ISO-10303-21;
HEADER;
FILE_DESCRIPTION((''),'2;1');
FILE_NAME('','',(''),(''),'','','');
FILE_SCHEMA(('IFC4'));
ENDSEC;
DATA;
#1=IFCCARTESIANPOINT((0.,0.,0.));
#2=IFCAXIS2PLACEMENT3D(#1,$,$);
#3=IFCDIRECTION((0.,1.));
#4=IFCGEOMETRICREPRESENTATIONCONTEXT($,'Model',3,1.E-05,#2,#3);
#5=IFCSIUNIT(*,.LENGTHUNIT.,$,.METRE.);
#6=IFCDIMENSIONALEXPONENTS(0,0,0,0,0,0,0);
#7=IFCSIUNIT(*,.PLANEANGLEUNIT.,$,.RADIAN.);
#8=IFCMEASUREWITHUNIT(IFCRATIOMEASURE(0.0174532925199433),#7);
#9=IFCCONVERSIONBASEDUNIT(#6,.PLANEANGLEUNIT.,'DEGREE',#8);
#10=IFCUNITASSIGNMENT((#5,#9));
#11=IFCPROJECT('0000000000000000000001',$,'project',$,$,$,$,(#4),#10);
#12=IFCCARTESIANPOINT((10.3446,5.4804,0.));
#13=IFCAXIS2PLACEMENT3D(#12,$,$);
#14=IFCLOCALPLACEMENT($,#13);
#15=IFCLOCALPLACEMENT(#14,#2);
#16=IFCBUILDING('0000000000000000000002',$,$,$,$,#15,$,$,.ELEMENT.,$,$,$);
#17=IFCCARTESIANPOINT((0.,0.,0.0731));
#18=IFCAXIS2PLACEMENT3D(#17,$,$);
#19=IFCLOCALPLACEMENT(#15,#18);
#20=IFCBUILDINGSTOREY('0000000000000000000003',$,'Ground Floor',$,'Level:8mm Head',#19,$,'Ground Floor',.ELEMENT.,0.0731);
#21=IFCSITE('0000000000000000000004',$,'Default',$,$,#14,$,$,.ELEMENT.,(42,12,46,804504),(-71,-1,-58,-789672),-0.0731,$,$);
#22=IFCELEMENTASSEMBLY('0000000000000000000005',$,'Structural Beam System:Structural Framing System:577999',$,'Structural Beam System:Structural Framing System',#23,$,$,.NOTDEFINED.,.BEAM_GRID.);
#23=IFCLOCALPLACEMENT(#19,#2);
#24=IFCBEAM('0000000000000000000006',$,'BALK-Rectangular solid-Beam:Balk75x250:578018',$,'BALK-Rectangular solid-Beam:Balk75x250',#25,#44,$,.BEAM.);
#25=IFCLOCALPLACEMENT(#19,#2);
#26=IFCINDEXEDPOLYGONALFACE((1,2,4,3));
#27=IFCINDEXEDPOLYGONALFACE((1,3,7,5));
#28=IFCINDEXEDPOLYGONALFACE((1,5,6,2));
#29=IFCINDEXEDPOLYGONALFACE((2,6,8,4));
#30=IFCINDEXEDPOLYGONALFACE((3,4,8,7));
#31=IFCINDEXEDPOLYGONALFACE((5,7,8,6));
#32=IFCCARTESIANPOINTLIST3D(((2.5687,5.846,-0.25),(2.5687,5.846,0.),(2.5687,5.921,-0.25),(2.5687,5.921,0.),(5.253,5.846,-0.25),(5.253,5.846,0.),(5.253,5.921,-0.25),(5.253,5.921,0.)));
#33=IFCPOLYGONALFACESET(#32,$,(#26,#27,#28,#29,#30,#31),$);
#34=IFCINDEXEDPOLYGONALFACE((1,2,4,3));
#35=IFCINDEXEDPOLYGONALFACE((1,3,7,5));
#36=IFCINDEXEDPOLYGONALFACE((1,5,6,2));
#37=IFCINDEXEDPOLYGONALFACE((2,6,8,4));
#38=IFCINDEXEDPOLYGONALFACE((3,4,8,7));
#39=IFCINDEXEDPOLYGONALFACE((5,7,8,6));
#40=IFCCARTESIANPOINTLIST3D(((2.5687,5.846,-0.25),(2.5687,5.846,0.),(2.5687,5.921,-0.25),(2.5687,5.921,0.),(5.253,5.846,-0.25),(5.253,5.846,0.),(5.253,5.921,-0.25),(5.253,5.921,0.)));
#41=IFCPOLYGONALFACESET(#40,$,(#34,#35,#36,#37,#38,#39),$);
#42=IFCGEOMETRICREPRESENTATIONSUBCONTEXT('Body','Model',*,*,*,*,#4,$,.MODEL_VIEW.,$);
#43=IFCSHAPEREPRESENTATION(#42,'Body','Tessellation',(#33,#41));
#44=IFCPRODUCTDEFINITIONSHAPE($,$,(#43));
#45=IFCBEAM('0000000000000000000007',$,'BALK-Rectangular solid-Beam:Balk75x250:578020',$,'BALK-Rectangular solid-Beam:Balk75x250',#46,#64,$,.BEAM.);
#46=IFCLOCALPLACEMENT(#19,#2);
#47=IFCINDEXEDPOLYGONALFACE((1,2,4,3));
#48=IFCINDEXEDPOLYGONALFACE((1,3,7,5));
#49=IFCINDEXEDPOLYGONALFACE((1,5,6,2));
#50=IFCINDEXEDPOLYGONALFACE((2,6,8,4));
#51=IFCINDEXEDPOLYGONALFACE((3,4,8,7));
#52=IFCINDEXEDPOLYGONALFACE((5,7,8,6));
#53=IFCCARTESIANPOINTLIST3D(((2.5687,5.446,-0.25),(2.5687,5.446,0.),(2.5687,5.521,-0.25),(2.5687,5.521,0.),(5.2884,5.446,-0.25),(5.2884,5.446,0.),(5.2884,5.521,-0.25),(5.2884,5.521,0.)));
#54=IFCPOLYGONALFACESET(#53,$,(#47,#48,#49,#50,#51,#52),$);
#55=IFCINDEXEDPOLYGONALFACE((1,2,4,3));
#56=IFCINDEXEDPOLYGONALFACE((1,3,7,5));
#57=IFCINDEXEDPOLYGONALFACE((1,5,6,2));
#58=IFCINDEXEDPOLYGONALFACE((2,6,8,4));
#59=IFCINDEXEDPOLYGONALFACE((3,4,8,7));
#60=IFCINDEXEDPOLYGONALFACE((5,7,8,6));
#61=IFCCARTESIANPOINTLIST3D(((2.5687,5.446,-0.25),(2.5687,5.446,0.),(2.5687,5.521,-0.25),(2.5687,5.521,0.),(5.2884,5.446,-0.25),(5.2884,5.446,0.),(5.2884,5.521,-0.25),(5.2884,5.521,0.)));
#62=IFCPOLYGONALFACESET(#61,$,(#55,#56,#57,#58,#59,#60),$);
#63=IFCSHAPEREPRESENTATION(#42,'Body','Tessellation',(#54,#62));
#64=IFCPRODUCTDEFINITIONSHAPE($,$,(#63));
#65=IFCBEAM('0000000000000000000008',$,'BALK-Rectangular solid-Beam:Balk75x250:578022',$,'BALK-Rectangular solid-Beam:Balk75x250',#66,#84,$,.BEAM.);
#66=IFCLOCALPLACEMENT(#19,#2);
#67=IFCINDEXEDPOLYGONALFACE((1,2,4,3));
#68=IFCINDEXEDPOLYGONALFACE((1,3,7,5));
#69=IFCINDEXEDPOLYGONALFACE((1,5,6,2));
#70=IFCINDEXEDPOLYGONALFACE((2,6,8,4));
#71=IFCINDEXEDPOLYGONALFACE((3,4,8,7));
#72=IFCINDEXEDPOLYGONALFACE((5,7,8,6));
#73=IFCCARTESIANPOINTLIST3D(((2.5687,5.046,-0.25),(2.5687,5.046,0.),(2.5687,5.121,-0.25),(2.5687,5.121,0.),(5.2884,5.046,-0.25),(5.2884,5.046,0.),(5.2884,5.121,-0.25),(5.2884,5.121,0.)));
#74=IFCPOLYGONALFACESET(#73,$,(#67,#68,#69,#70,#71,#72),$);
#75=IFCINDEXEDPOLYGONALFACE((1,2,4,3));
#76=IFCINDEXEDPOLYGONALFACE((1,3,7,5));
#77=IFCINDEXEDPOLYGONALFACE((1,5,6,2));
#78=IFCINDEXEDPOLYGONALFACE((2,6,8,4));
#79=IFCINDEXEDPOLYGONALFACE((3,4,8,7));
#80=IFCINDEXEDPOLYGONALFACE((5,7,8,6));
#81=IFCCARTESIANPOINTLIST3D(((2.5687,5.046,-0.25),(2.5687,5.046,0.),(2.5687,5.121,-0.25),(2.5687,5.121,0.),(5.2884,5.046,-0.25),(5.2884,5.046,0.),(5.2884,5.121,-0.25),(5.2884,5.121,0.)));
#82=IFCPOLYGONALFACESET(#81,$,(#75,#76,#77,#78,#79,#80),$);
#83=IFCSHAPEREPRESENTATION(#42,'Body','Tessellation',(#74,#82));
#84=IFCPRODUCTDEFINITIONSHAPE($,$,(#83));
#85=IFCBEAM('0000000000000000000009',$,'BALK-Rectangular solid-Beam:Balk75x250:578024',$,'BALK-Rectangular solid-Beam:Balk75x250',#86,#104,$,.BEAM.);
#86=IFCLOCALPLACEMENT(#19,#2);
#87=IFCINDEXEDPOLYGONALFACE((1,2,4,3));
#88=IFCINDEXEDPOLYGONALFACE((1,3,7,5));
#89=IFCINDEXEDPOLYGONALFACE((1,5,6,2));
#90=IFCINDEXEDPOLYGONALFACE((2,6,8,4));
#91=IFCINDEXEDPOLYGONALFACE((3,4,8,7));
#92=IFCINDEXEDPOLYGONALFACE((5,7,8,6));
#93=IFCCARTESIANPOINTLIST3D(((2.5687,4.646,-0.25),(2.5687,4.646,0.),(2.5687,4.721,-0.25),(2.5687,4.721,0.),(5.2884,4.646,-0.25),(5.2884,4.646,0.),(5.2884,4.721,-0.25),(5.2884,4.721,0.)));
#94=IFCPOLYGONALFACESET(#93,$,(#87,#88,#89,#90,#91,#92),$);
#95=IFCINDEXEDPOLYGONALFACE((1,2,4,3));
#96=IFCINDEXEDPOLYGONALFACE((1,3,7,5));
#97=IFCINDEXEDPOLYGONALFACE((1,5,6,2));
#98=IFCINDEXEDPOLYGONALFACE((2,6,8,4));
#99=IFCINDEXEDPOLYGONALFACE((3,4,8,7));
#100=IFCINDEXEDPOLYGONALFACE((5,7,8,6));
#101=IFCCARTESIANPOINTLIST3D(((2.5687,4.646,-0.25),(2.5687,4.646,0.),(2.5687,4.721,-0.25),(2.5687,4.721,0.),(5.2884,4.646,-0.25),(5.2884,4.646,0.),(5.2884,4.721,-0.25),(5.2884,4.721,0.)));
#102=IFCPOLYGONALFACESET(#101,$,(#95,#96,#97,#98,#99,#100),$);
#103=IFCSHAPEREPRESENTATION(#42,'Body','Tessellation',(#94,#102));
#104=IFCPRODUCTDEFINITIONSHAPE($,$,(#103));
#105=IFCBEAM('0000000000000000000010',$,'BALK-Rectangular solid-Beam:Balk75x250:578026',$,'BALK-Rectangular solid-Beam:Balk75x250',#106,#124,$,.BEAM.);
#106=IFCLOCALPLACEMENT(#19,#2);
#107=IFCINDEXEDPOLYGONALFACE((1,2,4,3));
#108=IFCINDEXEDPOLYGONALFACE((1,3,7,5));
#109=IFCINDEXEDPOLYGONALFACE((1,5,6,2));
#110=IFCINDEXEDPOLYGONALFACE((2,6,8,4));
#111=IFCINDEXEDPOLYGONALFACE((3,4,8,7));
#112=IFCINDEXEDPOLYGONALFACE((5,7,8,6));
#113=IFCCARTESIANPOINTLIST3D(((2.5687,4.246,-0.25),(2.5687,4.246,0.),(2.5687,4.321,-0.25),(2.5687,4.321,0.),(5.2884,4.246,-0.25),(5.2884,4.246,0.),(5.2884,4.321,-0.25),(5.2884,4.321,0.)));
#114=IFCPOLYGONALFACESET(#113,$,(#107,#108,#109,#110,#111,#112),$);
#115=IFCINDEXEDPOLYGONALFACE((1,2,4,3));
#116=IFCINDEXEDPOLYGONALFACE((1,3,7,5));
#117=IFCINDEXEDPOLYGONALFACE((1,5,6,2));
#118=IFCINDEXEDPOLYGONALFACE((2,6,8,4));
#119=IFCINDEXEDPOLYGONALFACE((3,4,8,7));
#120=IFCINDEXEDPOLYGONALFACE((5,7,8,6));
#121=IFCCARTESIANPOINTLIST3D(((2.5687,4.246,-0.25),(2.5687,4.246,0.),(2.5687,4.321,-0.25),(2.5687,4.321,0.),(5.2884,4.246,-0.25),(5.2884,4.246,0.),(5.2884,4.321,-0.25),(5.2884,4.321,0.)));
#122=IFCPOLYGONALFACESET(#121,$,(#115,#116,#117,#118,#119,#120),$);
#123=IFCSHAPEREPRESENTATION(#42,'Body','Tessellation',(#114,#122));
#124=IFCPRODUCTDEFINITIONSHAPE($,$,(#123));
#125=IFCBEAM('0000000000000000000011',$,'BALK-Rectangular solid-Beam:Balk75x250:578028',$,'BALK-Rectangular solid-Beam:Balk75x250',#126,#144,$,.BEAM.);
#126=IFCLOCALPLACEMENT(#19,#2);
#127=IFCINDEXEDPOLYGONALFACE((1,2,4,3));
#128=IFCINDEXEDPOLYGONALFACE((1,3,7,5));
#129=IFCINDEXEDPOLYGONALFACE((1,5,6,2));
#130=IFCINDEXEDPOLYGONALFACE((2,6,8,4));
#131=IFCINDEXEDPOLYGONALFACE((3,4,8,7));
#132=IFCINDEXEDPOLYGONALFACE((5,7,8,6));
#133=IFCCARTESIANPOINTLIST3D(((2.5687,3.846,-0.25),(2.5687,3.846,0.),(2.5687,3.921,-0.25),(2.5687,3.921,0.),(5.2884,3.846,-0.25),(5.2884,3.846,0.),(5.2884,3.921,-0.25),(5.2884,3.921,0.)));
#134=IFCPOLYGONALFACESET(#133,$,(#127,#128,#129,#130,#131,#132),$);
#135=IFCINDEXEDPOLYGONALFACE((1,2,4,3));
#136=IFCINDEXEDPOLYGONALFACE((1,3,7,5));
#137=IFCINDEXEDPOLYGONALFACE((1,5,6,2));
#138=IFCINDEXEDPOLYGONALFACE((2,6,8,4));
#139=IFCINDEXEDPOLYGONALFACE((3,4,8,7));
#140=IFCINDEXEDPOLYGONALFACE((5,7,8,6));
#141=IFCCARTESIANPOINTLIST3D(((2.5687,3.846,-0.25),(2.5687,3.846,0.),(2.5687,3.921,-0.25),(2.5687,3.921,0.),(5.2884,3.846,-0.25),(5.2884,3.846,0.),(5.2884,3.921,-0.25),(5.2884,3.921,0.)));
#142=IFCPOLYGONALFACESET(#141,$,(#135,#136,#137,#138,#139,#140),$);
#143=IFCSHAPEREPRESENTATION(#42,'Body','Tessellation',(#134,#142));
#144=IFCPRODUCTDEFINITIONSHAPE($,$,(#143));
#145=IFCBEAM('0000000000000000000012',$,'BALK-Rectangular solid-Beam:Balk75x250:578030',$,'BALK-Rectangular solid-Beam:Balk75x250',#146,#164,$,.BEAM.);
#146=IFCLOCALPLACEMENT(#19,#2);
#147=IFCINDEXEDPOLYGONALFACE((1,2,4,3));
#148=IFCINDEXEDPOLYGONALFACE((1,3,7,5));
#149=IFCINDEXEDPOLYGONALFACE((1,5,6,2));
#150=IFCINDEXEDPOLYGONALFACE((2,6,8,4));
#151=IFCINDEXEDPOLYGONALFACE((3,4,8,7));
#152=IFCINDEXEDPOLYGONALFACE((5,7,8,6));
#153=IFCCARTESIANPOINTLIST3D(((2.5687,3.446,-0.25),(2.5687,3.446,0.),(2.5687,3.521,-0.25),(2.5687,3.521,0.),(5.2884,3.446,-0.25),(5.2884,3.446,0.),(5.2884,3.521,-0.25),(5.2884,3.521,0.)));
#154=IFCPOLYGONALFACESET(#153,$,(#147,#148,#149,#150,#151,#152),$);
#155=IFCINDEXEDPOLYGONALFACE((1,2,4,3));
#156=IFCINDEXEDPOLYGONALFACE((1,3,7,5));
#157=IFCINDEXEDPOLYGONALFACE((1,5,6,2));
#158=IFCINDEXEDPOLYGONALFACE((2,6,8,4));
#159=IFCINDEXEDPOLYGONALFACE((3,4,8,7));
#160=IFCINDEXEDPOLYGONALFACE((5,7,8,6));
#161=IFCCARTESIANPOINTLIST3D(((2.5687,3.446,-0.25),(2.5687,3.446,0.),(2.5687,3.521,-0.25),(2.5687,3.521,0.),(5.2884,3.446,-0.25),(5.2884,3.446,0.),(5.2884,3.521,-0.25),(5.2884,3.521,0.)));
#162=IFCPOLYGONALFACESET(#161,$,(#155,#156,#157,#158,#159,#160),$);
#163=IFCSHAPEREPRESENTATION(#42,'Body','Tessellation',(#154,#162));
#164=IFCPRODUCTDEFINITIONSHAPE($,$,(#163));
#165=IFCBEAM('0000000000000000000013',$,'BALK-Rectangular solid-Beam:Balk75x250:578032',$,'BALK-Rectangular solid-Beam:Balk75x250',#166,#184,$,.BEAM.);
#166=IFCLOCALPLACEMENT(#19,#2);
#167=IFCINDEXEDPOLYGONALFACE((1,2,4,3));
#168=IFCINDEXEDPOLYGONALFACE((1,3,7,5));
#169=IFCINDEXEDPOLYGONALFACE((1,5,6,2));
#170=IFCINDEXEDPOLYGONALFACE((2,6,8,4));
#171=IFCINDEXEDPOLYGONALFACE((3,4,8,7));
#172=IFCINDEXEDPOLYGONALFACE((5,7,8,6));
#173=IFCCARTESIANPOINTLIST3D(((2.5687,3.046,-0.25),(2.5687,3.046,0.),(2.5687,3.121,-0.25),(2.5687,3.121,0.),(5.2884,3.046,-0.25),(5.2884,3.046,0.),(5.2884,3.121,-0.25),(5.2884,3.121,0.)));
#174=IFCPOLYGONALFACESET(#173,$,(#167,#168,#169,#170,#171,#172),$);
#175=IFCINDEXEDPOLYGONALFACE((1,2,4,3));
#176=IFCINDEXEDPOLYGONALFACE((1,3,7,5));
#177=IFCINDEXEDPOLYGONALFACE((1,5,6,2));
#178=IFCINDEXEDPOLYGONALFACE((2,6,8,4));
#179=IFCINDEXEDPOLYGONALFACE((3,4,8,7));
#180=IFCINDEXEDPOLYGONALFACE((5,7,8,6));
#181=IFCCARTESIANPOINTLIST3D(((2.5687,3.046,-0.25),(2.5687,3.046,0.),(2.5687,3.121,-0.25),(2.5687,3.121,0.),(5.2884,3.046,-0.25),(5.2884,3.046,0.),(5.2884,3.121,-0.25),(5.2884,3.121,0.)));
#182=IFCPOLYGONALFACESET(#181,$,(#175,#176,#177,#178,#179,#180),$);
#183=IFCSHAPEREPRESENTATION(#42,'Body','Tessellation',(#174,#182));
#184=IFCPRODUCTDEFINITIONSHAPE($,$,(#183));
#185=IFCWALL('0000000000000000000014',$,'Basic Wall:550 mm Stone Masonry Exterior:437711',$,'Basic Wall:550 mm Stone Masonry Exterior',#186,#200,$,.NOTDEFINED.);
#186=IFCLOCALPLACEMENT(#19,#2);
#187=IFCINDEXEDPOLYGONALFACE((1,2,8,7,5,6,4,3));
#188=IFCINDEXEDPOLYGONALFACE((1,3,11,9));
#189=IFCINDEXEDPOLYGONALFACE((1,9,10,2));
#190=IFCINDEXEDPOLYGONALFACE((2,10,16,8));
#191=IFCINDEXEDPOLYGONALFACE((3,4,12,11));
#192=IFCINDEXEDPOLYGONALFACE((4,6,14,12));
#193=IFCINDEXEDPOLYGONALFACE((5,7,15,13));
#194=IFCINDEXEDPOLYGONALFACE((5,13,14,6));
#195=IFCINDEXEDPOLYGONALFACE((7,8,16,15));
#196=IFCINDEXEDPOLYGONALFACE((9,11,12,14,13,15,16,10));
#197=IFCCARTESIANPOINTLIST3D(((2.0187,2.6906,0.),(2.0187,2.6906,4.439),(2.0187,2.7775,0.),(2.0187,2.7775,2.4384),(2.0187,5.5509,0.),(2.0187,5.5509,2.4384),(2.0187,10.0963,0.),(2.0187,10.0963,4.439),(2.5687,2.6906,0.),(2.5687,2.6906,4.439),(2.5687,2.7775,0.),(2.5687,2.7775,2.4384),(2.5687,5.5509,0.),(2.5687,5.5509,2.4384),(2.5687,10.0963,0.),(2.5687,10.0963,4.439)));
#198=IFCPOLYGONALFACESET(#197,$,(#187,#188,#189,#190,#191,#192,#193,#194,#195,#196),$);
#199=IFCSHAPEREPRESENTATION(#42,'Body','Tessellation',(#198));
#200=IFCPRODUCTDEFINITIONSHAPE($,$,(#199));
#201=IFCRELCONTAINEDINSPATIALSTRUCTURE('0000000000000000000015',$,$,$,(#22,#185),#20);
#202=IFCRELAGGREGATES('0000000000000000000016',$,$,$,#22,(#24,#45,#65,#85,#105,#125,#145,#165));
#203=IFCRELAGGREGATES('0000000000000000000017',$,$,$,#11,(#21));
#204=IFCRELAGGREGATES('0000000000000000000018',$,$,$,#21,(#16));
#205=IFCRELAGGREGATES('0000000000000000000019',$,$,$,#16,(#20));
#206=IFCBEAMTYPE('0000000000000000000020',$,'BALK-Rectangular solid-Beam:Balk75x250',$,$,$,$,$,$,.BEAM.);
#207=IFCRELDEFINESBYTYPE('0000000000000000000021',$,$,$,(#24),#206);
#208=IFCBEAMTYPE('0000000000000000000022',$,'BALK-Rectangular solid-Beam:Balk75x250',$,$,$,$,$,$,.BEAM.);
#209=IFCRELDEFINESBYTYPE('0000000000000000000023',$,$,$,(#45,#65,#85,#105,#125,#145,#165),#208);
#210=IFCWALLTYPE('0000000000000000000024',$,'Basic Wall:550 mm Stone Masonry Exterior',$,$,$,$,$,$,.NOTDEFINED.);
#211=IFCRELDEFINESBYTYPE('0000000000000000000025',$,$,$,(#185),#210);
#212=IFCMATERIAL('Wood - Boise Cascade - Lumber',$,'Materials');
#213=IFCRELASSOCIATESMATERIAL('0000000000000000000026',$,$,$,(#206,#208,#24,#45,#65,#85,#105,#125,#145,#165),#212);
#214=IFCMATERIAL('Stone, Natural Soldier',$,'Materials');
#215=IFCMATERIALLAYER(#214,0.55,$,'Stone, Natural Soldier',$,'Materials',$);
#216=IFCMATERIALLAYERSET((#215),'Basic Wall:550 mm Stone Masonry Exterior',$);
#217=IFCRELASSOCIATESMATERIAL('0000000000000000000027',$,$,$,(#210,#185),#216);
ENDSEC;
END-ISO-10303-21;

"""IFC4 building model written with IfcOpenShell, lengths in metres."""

from ifc_helpers import new_model, entity, si_unit, converted_unit, direction, frame, frame_2d, origin, origin_2d_with_axis, place, context, subcontext, project, spatial, rectangle, extrude, source, transform, mapped, material, layer, layer_set, layer_usage, material_profile, profile_set, profile_usage, type_object, type_shapes, element, aggregate, save


model = new_model("IFC4")

# Units and contexts
model_context = context("Model", 3, precision=1e-05, world=origin(), true_north=direction((0.0, 1.0)))
body_context = subcontext(model_context, "Body", "Model", "MODEL_VIEW")
ifc_project = project(units=[si_unit("LENGTHUNIT", "METRE"), converted_unit("PLANEANGLEUNIT", "DEGREE", entity("IfcRatioMeasure", 0.0174532925199433), si_unit("PLANEANGLEUNIT", "RADIAN"), dimensions=[0, 0, 0, 0, 0, 0, 0])], contexts=[model_context])

# Site, building, storey
site_placement = place(None, frame((10.3446, 5.4804, 0.0)))
site = spatial("IfcSite", under=ifc_project, at=site_placement, Name="Default", CompositionType="ELEMENT", RefLatitude=(42, 12, 46, 804504), RefLongitude=(-71, -1, -58, -789672), RefElevation=-0.0731)
building_placement = place(site_placement, origin())
building = spatial("IfcBuilding", under=site, at=building_placement, CompositionType="ELEMENT")
storey_placement = place(building_placement, frame((0.0, 0.0, 0.0731)))
storey = spatial("IfcBuildingStorey", under=building, at=storey_placement, Name="Ground Floor", ObjectType="Level:8mm Head", LongName="Ground Floor", CompositionType="ELEMENT", Elevation=0.0731)

# Shared definitions
ifc_material_1 = material(Name="Wood - Boise Cascade - Lumber", Category="Materials")
ifc_material_profile = material_profile(ifc_material_1, rectangle(XDim=0.25, YDim=0.075, at=frame_2d((0.0, 0.0), x_axis=(1.0, 0.0))), Name="Balk75x250")
ifc_profile_set = profile_set([ifc_material_profile], Name="Balk75x250")

# Element assembly, beams
assembly_1_placement = place(storey_placement, origin())
assembly_1 = element("IfcElementAssembly", 1, at=assembly_1_placement, inside=storey, Name="Structural Beam System:Structural Framing System:577999", ObjectType="Structural Beam System:Structural Framing System", AssemblyPlace="NOTDEFINED", PredefinedType="BEAM_GRID")
beam_type_1 = type_object("IfcBeamType", Name="BALK-Rectangular solid-Beam:Balk75x250", PredefinedType="BEAM", material=ifc_profile_set)
shared_shape_1 = source(origin(), body_context, "Body", "SweptSolid", [
    extrude(rectangle(XDim=0.25, YDim=0.075, at=origin_2d_with_axis()), frame((-1.3484, 0.0, 0.0), z_axis=(1.0, 0.0, 0.0), x_axis=(0.0, 0.0, -1.0)), (0.0, 0.0, 1.0), 2.6844),
    extrude(rectangle(XDim=0.25, YDim=0.075, at=origin_2d_with_axis()), frame((-1.3484, 0.0, 0.0), z_axis=(1.0, 0.0, 0.0), x_axis=(0.0, 0.0, -1.0)), (0.0, 0.0, 1.0), 2.6844),
])
type_shapes(beam_type_1, [shared_shape_1])
ifc_profile_usage_1 = profile_usage(ifc_profile_set, cardinal=8)
beam_1_placement = place(assembly_1_placement, frame((3.9171, 5.8835, -0.125)))
beam_1 = element("IfcBeam", 2, at=beam_1_placement, type_object=beam_type_1, material=ifc_profile_usage_1, Name="BALK-Rectangular solid-Beam:Balk75x250:578018", ObjectType="BALK-Rectangular solid-Beam:Balk75x250", PredefinedType="BEAM", context=body_context, shape_type="MappedRepresentation", body=[
    mapped(shared_shape_1, transform((0.0, 0.0, 0.0), scale=1.0)),
])
ifc_profile_usage_2 = profile_usage(ifc_profile_set, cardinal=8)
beam_type_2 = type_object("IfcBeamType", Name="BALK-Rectangular solid-Beam:Balk75x250", PredefinedType="BEAM", material=ifc_profile_set)
shared_shape_2 = source(origin(), body_context, "Body", "SweptSolid", [
    extrude(rectangle(XDim=0.25, YDim=0.075, at=origin_2d_with_axis()), frame((-1.3599, 0.0, 0.0), z_axis=(1.0, 0.0, 0.0), x_axis=(0.0, 0.0, -1.0)), (0.0, 0.0, 1.0), 2.7197),
    extrude(rectangle(XDim=0.25, YDim=0.075, at=origin_2d_with_axis()), frame((-1.3599, 0.0, 0.0), z_axis=(1.0, 0.0, 0.0), x_axis=(0.0, 0.0, -1.0)), (0.0, 0.0, 1.0), 2.7197),
])
type_shapes(beam_type_2, [shared_shape_2])
beam_2_placement = place(assembly_1_placement, frame((3.9285, 5.4835, -0.125)))
beam_2 = element("IfcBeam", 3, at=beam_2_placement, type_object=beam_type_2, material=ifc_profile_usage_2, Name="BALK-Rectangular solid-Beam:Balk75x250:578020", ObjectType="BALK-Rectangular solid-Beam:Balk75x250", PredefinedType="BEAM", context=body_context, shape_type="MappedRepresentation", body=[
    mapped(shared_shape_2, transform((0.0, 0.0, 0.0), scale=1.0)),
])
ifc_profile_usage_3 = profile_usage(ifc_profile_set, cardinal=8)
beam_3_placement = place(assembly_1_placement, frame((3.9285, 5.0835, -0.125)))
beam_3 = element("IfcBeam", 4, at=beam_3_placement, type_object=beam_type_2, material=ifc_profile_usage_3, Name="BALK-Rectangular solid-Beam:Balk75x250:578022", ObjectType="BALK-Rectangular solid-Beam:Balk75x250", PredefinedType="BEAM", context=body_context, shape_type="MappedRepresentation", body=[
    mapped(shared_shape_2, transform((0.0, 0.0, 0.0), scale=1.0)),
])
ifc_profile_usage_4 = profile_usage(ifc_profile_set, cardinal=8)
beam_4_placement = place(assembly_1_placement, frame((3.9285, 4.6835, -0.125)))
beam_4 = element("IfcBeam", 5, at=beam_4_placement, type_object=beam_type_2, material=ifc_profile_usage_4, Name="BALK-Rectangular solid-Beam:Balk75x250:578024", ObjectType="BALK-Rectangular solid-Beam:Balk75x250", PredefinedType="BEAM", context=body_context, shape_type="MappedRepresentation", body=[
    mapped(shared_shape_2, transform((0.0, 0.0, 0.0), scale=1.0)),
])
ifc_profile_usage_5 = profile_usage(ifc_profile_set, cardinal=8)
beam_5_placement = place(assembly_1_placement, frame((3.9285, 4.2835, -0.125)))
beam_5 = element("IfcBeam", 6, at=beam_5_placement, type_object=beam_type_2, material=ifc_profile_usage_5, Name="BALK-Rectangular solid-Beam:Balk75x250:578026", ObjectType="BALK-Rectangular solid-Beam:Balk75x250", PredefinedType="BEAM", context=body_context, shape_type="MappedRepresentation", body=[
    mapped(shared_shape_2, transform((0.0, 0.0, 0.0), scale=1.0)),
])
ifc_profile_usage_6 = profile_usage(ifc_profile_set, cardinal=8)
beam_6_placement = place(assembly_1_placement, frame((3.9285, 3.8835, -0.125)))
beam_6 = element("IfcBeam", 7, at=beam_6_placement, type_object=beam_type_2, material=ifc_profile_usage_6, Name="BALK-Rectangular solid-Beam:Balk75x250:578028", ObjectType="BALK-Rectangular solid-Beam:Balk75x250", PredefinedType="BEAM", context=body_context, shape_type="MappedRepresentation", body=[
    mapped(shared_shape_2, transform((0.0, 0.0, 0.0), scale=1.0)),
])
ifc_profile_usage_7 = profile_usage(ifc_profile_set, cardinal=8)
beam_7_placement = place(assembly_1_placement, frame((3.9285, 3.4835, -0.125)))
beam_7 = element("IfcBeam", 8, at=beam_7_placement, type_object=beam_type_2, material=ifc_profile_usage_7, Name="BALK-Rectangular solid-Beam:Balk75x250:578030", ObjectType="BALK-Rectangular solid-Beam:Balk75x250", PredefinedType="BEAM", context=body_context, shape_type="MappedRepresentation", body=[
    mapped(shared_shape_2, transform((0.0, 0.0, 0.0), scale=1.0)),
])
ifc_profile_usage_8 = profile_usage(ifc_profile_set, cardinal=8)
beam_8_placement = place(assembly_1_placement, frame((3.9285, 3.0835, -0.125)))
beam_8 = element("IfcBeam", 9, at=beam_8_placement, type_object=beam_type_2, material=ifc_profile_usage_8, Name="BALK-Rectangular solid-Beam:Balk75x250:578032", ObjectType="BALK-Rectangular solid-Beam:Balk75x250", PredefinedType="BEAM", context=body_context, shape_type="MappedRepresentation", body=[
    mapped(shared_shape_2, transform((0.0, 0.0, 0.0), scale=1.0)),
])
aggregate(assembly_1, [beam_1, beam_2, beam_3, beam_4, beam_5, beam_6, beam_7, beam_8])

# Wall, opening
ifc_material_2 = material(Name="Stone, Natural Soldier", Category="Materials")
ifc_layer_1 = layer(ifc_material_2, 0.55, Name="Stone, Natural Soldier", Category="Materials")
ifc_layer_set_1 = layer_set([ifc_layer_1], Name="Basic Wall:550 mm Stone Masonry Exterior")
ifc_layer_usage_1 = layer_usage(ifc_layer_set_1, "AXIS2", "NEGATIVE", 0.275)
wall_type_1 = type_object("IfcWallType", Name="Basic Wall:550 mm Stone Masonry Exterior", PredefinedType="NOTDEFINED", material=ifc_layer_set_1)
wall_1_placement = place(storey_placement, frame((2.2937, 10.0963, 0.0), z_axis=(0.0, 0.0, 1.0), x_axis=(0.0, -1.0, 0.0)))
wall_1 = element("IfcWall", 10, at=wall_1_placement, inside=storey, type_object=wall_type_1, material=ifc_layer_usage_1, Name="Basic Wall:550 mm Stone Masonry Exterior:437711", ObjectType="Basic Wall:550 mm Stone Masonry Exterior", PredefinedType="NOTDEFINED", context=body_context, shape_type="SweptSolid", body=[
    extrude(rectangle(XDim=7.4057, YDim=0.55, at=frame_2d((3.7028, 0.0), x_axis=(-1.0, 0.0))), origin(), (0.0, 0.0, 1.0), 4.439),
])
opening_1_placement = place(wall_1_placement, frame((7.3188, -0.275, 0.0)))
element("IfcOpeningElement", 11, at=opening_1_placement, cuts=wall_1, ObjectType="Opening", PredefinedType="OPENING", context=body_context, shape_type="SweptSolid", body=[
    extrude(rectangle(XDim=2.4384, YDim=2.7734, at=origin_2d_with_axis()), frame((-1.3867, 0.0, 1.2192), z_axis=(0.0, 1.0, 0.0), x_axis=(0.0, 0.0, -1.0)), (0.0, 0.0, 1.0), 0.55),
])

save(model, "model.ifc")
